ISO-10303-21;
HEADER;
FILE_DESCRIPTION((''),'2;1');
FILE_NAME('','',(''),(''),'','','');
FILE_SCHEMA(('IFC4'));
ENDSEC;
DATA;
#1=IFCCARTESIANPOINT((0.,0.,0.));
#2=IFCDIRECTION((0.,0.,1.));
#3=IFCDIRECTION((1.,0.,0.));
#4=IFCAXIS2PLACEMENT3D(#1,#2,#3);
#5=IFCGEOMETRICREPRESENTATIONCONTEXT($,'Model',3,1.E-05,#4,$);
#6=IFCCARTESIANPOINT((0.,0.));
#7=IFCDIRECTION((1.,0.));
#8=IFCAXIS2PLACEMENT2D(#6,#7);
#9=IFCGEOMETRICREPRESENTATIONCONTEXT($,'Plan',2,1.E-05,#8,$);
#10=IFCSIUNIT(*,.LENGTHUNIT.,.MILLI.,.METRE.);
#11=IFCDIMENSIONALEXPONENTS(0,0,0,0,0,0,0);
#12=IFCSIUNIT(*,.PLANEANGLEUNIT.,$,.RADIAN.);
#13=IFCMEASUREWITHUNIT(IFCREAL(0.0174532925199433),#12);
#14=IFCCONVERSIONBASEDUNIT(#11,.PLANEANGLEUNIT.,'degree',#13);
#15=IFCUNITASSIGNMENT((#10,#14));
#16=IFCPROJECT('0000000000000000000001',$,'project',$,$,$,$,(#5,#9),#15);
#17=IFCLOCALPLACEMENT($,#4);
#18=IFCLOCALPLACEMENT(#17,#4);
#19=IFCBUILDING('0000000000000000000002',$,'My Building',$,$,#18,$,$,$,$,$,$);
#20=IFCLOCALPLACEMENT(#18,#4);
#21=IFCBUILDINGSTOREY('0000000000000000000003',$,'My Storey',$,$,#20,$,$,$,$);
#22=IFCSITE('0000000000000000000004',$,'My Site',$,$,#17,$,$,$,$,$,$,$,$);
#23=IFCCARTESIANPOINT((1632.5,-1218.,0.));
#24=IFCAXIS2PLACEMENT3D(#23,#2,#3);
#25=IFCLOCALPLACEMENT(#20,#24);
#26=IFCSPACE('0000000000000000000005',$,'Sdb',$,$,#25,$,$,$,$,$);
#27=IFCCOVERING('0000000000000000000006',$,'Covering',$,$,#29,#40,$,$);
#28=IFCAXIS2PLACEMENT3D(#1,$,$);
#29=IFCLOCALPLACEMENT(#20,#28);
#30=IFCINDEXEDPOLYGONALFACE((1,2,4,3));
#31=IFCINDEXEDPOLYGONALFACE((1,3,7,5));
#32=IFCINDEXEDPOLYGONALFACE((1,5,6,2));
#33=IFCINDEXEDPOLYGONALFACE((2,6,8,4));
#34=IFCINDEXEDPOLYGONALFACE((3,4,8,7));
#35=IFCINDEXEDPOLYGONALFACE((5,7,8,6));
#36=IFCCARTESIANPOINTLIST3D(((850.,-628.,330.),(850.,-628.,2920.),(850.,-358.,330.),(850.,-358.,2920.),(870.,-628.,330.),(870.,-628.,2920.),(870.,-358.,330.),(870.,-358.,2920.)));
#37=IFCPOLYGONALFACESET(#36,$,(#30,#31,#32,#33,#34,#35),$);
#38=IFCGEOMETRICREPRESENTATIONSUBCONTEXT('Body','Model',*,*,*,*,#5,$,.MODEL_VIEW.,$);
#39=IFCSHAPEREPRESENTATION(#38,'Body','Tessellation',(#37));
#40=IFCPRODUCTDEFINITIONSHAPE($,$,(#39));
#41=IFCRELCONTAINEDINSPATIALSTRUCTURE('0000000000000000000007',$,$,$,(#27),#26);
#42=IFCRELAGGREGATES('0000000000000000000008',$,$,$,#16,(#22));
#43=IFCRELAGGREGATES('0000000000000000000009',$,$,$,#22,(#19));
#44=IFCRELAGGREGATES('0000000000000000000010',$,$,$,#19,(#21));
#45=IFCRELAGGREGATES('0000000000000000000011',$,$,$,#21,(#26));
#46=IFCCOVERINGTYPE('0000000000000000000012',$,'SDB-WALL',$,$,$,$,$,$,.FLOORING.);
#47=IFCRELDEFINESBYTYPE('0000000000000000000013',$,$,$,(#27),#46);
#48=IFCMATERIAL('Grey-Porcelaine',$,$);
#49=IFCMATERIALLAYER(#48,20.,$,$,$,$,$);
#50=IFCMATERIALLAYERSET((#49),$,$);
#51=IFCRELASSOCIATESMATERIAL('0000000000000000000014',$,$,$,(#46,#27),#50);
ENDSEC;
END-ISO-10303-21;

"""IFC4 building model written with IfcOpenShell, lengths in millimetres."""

from ifc_helpers import new_model, entity, si_unit, converted_unit, frame, origin_with_axes, origin_2d_with_axis, place, context, subcontext, project, spatial, indexed_curve, outline, extrude, clip, halfspace, material, layer, layer_set, layer_usage, type_object, element, save


model = new_model("IFC4")

# Units and contexts
model_context = context("Model", 3, precision=1e-05, world=origin_with_axes())
plan_context = context("Plan", 2, precision=1e-05, world=origin_2d_with_axis())
body_context = subcontext(model_context, "Body", "Model", "MODEL_VIEW")
ifc_project = project(units=[si_unit("LENGTHUNIT", "METRE", prefix="MILLI"), converted_unit("PLANEANGLEUNIT", "degree", entity("IfcReal", 0.0174532925199433), si_unit("PLANEANGLEUNIT", "RADIAN"), dimensions=[0, 0, 0, 0, 0, 0, 0])], contexts=[model_context, plan_context])

# Site, building, storey, space
site_placement = place(None, origin_with_axes())
site = spatial("IfcSite", under=ifc_project, at=site_placement, Name="My Site")
building_placement = place(site_placement, origin_with_axes())
building = spatial("IfcBuilding", under=site, at=building_placement, Name="My Building")
storey_placement = place(building_placement, origin_with_axes())
storey = spatial("IfcBuildingStorey", under=building, at=storey_placement, Name="My Storey")
space_1_placement = place(storey_placement, frame((1632.5, -1218.0, 0.0), z_axis=(0.0, 0.0, 1.0), x_axis=(1.0, 0.0, 0.0)))
space_1 = spatial("IfcSpace", under=storey, at=space_1_placement, Name="Sdb")

# Covering
ifc_material_1 = material(Name="Grey-Porcelaine")
ifc_layer_1 = layer(ifc_material_1, 20.0)
ifc_layer_set_1 = layer_set([ifc_layer_1])
covering_type_1 = type_object("IfcCoveringType", Name="SDB-WALL", PredefinedType="FLOORING", material=ifc_layer_set_1)
ifc_layer_usage_1 = layer_usage(ifc_layer_set_1, "AXIS2", "POSITIVE", 0.0)
covering_1_placement = place(space_1_placement, frame((-782.5, 860.0, 330.0), z_axis=(0.0, 0.0, 1.0), x_axis=(-0.000004, -1.0, 0.0)))
element("IfcCovering", 1, at=covering_1_placement, inside=space_1, type_object=covering_type_1, material=ifc_layer_usage_1, Name="Covering", context=body_context, shape_type="Clipping", body=[
    clip(extrude(outline(indexed_curve([(0.0, 0.0), (0.0, 20.0), (270.0, 20.0), (270.0, 0.0), (0.0, 0.0)], self_intersect=False)), origin_with_axes(), (0.0, 0.0, 1.0), 2920.0), halfspace(frame((0.0, 0.0, 2590.0), z_axis=(0.0, 0.0, 1.0), x_axis=(-1.0, 0.0, 0.0)), False)),
])

save(model, "model.ifc")
